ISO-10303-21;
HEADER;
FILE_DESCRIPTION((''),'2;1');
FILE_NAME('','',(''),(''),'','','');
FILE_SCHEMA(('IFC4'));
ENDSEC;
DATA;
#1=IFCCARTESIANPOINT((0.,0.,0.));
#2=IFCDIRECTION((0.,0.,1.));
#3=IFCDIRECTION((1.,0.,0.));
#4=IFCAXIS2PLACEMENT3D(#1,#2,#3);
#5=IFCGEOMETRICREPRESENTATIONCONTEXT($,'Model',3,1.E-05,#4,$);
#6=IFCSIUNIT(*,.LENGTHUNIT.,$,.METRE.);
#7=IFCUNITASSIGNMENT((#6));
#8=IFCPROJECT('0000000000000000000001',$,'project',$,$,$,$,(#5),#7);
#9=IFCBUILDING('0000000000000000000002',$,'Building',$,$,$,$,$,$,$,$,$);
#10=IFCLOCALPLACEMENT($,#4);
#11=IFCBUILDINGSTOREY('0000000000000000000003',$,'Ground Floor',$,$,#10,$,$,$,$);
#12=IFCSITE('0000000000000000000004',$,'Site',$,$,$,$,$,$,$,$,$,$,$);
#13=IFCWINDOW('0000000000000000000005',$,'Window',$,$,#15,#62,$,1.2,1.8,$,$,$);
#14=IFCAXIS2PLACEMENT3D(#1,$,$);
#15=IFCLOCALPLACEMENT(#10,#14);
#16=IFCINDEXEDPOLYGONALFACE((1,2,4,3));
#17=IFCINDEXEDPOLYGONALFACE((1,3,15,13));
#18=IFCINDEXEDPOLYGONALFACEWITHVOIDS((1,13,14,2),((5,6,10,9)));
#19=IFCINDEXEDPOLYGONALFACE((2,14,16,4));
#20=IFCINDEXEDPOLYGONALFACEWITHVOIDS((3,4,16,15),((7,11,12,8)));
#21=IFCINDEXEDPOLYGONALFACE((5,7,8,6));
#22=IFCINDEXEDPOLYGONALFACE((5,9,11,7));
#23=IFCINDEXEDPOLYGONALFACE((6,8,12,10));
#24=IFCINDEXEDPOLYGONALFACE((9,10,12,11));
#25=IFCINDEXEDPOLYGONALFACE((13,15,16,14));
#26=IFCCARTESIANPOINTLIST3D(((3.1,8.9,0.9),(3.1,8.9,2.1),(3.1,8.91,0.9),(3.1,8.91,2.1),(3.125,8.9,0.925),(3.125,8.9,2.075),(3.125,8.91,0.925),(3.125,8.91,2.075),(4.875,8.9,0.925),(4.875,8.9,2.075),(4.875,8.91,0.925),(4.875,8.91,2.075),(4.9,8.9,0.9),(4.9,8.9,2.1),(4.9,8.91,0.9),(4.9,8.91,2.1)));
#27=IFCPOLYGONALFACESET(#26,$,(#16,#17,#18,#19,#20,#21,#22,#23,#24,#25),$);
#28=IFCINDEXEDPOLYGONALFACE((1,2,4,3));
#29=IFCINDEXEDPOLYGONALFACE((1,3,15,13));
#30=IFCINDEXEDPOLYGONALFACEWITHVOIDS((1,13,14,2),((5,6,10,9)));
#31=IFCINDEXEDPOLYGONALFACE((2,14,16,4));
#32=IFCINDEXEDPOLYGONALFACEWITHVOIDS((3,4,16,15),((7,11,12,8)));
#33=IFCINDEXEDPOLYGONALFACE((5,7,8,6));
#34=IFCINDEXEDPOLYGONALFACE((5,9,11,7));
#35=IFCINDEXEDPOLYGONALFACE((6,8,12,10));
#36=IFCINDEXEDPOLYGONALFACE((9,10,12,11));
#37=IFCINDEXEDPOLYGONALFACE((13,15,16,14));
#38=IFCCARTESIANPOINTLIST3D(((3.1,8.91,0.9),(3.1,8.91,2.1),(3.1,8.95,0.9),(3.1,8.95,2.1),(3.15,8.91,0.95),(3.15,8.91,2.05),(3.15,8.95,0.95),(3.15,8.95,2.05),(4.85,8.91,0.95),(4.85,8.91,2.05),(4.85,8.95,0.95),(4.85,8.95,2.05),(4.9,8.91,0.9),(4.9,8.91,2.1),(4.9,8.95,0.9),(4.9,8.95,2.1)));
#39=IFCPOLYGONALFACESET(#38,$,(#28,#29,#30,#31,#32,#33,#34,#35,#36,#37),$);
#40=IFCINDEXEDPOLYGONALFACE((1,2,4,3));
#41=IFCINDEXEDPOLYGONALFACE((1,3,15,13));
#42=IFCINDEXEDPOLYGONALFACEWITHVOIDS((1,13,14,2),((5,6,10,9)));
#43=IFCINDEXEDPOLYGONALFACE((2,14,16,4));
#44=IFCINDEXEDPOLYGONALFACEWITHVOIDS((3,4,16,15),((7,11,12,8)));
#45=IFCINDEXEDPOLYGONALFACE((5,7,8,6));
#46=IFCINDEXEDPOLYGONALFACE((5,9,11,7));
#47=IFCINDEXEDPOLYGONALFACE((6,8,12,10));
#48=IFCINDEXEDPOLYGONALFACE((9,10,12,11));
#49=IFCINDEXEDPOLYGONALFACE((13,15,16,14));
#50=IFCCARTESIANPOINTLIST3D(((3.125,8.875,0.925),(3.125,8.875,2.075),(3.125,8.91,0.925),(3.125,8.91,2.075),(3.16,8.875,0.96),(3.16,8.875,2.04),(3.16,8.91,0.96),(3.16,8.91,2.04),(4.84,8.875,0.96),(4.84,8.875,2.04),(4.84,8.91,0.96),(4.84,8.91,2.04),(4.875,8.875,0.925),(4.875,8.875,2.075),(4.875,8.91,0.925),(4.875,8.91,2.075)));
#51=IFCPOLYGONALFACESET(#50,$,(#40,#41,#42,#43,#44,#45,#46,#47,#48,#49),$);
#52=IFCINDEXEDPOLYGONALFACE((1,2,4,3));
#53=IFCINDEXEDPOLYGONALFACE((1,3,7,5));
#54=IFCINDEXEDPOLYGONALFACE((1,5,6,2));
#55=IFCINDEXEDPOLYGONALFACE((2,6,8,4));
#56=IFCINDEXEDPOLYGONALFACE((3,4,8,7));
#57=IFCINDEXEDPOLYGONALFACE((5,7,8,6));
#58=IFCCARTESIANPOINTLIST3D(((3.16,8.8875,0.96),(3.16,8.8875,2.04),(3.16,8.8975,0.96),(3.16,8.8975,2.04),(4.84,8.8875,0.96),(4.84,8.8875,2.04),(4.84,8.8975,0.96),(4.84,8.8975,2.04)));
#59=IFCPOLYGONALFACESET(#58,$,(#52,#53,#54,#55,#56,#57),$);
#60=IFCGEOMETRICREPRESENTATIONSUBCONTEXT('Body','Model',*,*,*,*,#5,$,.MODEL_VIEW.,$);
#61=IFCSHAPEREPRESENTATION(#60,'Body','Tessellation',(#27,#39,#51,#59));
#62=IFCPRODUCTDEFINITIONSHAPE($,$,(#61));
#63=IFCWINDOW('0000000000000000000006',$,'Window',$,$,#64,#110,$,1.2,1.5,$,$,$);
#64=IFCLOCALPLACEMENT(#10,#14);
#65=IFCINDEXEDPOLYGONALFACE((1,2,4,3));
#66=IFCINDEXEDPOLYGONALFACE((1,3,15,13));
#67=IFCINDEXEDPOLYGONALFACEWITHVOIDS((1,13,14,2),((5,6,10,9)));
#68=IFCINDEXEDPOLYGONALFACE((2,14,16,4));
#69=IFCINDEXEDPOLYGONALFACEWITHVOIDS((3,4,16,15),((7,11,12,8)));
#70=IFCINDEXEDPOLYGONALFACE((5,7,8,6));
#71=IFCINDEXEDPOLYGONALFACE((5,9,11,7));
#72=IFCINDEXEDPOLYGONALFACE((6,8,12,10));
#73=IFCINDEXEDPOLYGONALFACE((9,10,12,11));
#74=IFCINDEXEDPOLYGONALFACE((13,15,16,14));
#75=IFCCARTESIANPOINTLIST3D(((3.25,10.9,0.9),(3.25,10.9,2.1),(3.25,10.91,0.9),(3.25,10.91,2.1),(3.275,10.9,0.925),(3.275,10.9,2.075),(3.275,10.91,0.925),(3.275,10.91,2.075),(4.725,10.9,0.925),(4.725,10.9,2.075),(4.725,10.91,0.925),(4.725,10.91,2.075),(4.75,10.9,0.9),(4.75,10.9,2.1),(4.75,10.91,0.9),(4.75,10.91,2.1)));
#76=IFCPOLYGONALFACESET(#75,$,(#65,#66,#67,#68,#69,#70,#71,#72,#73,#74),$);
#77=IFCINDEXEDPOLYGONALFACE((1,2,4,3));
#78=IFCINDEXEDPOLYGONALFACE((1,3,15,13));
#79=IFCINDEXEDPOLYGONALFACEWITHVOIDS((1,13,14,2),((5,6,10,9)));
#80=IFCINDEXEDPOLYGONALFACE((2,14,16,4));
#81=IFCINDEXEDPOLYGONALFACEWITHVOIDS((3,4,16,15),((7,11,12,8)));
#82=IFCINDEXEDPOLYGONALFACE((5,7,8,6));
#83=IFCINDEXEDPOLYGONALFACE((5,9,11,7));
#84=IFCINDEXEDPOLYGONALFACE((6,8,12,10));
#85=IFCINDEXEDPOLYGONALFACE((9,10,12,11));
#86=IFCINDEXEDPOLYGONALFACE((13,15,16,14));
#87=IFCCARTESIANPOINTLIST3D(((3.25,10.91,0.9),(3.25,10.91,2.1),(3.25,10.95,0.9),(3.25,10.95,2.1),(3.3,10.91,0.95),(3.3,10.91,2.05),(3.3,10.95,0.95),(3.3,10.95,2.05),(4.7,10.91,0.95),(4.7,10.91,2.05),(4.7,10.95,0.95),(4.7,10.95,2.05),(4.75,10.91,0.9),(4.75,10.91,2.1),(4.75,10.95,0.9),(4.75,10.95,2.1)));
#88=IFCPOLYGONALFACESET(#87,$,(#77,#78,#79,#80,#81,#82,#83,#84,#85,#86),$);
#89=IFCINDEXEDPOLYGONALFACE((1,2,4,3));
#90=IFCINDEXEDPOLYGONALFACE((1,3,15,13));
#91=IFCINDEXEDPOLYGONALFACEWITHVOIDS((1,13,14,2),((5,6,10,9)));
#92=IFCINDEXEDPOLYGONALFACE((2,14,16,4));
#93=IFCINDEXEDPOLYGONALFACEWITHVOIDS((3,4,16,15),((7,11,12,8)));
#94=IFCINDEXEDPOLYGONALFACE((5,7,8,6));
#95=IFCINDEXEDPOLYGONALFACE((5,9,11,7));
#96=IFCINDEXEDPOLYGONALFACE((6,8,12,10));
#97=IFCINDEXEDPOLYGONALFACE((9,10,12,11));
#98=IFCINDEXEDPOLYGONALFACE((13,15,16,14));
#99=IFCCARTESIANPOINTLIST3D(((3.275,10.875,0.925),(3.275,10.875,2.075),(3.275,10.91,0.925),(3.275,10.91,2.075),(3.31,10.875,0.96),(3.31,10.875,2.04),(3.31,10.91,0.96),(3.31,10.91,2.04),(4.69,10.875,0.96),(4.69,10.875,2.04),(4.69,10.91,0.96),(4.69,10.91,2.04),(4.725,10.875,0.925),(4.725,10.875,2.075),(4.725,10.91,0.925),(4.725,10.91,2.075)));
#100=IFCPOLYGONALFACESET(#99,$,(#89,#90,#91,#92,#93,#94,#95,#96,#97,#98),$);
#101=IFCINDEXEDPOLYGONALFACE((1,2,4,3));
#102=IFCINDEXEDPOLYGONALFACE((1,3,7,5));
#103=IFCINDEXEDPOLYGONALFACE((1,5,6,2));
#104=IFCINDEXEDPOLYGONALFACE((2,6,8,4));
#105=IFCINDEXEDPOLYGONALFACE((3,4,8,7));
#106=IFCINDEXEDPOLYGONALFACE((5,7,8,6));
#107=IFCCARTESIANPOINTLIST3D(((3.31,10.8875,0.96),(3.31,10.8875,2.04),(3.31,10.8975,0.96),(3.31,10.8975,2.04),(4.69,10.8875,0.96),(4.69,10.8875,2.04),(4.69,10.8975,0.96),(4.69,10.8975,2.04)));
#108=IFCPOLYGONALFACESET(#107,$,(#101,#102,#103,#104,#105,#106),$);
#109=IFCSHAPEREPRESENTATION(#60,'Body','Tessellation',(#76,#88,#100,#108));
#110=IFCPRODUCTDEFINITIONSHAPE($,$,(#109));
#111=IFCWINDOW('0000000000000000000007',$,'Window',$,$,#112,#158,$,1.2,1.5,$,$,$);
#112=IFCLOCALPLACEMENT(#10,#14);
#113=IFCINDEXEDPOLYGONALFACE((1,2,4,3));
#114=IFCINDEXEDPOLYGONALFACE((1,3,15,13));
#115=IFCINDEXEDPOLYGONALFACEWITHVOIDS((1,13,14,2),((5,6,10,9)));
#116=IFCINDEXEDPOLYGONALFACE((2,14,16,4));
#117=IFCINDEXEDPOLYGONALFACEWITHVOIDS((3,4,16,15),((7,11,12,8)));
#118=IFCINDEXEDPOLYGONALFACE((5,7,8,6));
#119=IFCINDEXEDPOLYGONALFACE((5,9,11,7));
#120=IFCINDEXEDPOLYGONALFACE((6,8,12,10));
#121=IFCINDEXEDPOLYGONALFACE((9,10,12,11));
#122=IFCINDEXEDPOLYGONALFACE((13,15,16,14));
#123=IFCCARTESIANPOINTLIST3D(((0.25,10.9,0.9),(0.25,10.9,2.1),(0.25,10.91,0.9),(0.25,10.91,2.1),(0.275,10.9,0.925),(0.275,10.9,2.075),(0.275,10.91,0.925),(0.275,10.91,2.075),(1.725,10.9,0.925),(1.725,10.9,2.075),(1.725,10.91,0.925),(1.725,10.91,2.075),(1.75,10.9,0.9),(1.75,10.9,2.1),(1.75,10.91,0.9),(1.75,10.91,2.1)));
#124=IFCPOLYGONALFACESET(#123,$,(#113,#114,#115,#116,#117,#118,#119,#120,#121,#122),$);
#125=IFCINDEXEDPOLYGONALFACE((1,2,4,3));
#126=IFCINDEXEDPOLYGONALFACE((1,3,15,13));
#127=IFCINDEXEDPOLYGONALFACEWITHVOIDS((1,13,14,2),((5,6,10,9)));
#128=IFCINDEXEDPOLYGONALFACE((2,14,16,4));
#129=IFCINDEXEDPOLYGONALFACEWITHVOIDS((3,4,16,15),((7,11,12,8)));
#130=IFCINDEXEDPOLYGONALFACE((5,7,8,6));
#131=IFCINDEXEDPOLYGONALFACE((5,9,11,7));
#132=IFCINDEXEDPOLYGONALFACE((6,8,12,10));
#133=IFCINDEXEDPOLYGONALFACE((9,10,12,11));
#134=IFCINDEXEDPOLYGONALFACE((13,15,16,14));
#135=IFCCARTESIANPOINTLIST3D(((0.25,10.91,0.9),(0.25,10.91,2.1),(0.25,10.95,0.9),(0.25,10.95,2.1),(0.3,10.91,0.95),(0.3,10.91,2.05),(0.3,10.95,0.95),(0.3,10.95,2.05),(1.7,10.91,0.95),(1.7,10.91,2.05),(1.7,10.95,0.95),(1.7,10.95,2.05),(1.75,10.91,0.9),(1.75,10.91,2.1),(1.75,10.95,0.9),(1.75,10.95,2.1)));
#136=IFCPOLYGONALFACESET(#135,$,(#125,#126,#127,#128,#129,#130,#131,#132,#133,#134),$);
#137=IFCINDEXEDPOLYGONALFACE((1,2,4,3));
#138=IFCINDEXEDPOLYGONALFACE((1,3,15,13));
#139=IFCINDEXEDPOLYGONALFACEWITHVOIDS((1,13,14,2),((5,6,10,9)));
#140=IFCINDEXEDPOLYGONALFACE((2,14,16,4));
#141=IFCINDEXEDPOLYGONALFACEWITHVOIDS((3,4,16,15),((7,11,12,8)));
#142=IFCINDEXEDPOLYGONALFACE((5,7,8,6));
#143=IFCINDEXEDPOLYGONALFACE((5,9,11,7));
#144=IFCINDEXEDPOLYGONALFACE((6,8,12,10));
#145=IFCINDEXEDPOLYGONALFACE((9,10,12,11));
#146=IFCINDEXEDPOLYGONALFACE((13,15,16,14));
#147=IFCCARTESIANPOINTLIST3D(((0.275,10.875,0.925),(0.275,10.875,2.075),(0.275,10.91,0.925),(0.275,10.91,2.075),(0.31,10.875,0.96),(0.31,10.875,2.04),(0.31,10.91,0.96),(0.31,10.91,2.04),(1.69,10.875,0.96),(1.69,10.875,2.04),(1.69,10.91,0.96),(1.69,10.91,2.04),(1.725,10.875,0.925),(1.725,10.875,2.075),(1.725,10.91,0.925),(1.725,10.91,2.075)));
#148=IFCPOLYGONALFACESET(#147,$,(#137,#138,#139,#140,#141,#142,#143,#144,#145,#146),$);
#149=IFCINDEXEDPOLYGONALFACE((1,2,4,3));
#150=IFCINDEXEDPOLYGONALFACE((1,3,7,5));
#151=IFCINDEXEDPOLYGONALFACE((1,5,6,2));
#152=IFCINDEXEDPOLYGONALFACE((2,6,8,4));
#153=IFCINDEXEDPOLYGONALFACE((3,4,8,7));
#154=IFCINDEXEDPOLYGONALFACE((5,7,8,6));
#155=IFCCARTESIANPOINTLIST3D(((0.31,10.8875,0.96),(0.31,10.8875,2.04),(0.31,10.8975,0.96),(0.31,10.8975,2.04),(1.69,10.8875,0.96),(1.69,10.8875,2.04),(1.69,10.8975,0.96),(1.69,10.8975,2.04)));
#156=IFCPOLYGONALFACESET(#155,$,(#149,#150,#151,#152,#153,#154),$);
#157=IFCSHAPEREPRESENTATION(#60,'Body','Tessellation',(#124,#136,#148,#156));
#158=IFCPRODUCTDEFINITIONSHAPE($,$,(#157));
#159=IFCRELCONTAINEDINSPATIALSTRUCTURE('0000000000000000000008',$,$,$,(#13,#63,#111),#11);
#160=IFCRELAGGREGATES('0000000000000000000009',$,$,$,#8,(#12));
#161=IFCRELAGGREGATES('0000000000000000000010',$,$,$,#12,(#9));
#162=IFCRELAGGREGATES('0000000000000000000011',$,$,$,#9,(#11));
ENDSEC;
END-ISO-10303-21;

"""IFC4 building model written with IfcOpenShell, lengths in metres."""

from ifc_helpers import new_model, si_unit, frame, origin_with_axes, place, context, subcontext, project, spatial, line, indexed_curve, outline, extrude, element, save


model = new_model("IFC4")

# Units and contexts
model_context = context("Model", 3, precision=1e-05, world=origin_with_axes())
body_context = subcontext(model_context, "Body", "Model", "MODEL_VIEW")
ifc_project = project(units=[si_unit("LENGTHUNIT", "METRE")], contexts=[model_context])

# Site, building, storey
site = spatial("IfcSite", under=ifc_project, Name="Site")
building = spatial("IfcBuilding", under=site, Name="Building")
storey_placement = place(None, origin_with_axes())
storey = spatial("IfcBuildingStorey", under=building, at=storey_placement, Name="Ground Floor")

# Windows
window_placement = place(storey_placement, frame((4.9, 9.0, 0.9), z_axis=(0.0, 0.0, 1.0), x_axis=(-1.0, 0.0, 0.0)))
element("IfcWindow", 1, at=window_placement, inside=storey, Name="Window", OverallHeight=1.2, OverallWidth=1.8, context=body_context, shape_type="SweptSolid", body=[
    extrude(outline(indexed_curve([(0.0, 0.0), (1.8, 0.0), (1.8, 1.2), (0.0, 1.2)], segments=[line(1, 2, 3, 4, 1)]), holes=[indexed_curve([(0.025, 0.025), (1.775, 0.025), (1.775, 1.175), (0.025, 1.175)], segments=[line(1, 2, 3, 4, 1)])]), frame((0.0, 0.09, 0.0), z_axis=(0.0, -1.0, 0.0), x_axis=(1.0, 0.0, 0.0)), (0.0, 0.0, -1.0), 0.01),
    extrude(outline(indexed_curve([(0.0, 0.0), (1.8, 0.0), (1.8, 1.2), (0.0, 1.2)], segments=[line(1, 2, 3, 4, 1)]), holes=[indexed_curve([(0.05, 0.05), (1.75, 0.05), (1.75, 1.15), (0.05, 1.15)], segments=[line(1, 2, 3, 4, 1)])]), frame((0.0, 0.05, 0.0), z_axis=(0.0, -1.0, 0.0), x_axis=(1.0, 0.0, 0.0)), (0.0, 0.0, -1.0), 0.04),
    extrude(outline(indexed_curve([(0.0, 0.0), (1.75, 0.0), (1.75, 1.15), (0.0, 1.15)], segments=[line(1, 2, 3, 4, 1)]), holes=[indexed_curve([(0.035, 0.035), (1.715, 0.035), (1.715, 1.115), (0.035, 1.115)], segments=[line(1, 2, 3, 4, 1)])]), frame((0.025, 0.09, 0.025), z_axis=(0.0, -1.0, 0.0), x_axis=(1.0, 0.0, 0.0)), (0.0, 0.0, -1.0), 0.035),
    extrude(outline(indexed_curve([(0.035, 0.035), (1.715, 0.035), (1.715, 1.115), (0.035, 1.115)], segments=[line(1, 2, 3, 4, 1)])), frame((0.025, 0.1025, 0.025), z_axis=(0.0, -1.0, 0.0), x_axis=(1.0, 0.0, 0.0)), (0.0, 0.0, -1.0), 0.01),
])
for number, where, z_axis, x_axis, name in (
    (2, (4.75, 11.0, 0.9), (0.0, 0.0, 1.0), (-1.0, 0.0, 0.0), "Window"),
    (3, (1.75, 11.0, 0.9), (0.0, 0.0, 1.0), (-1.0, 0.0, 0.0), "Window"),
):
    element("IfcWindow", number, at=place(storey_placement, frame(where, z_axis=z_axis, x_axis=x_axis)), inside=storey, Name=name, OverallHeight=1.2, OverallWidth=1.5, context=body_context, shape_type="SweptSolid", body=[
        extrude(outline(indexed_curve([(0.0, 0.0), (1.5, 0.0), (1.5, 1.2), (0.0, 1.2)], segments=[line(1, 2, 3, 4, 1)]), holes=[indexed_curve([(0.025, 0.025), (1.475, 0.025), (1.475, 1.175), (0.025, 1.175)], segments=[line(1, 2, 3, 4, 1)])]), frame((0.0, 0.09, 0.0), z_axis=(0.0, -1.0, 0.0), x_axis=(1.0, 0.0, 0.0)), (0.0, 0.0, -1.0), 0.01),
        extrude(outline(indexed_curve([(0.0, 0.0), (1.5, 0.0), (1.5, 1.2), (0.0, 1.2)], segments=[line(1, 2, 3, 4, 1)]), holes=[indexed_curve([(0.05, 0.05), (1.45, 0.05), (1.45, 1.15), (0.05, 1.15)], segments=[line(1, 2, 3, 4, 1)])]), frame((0.0, 0.05, 0.0), z_axis=(0.0, -1.0, 0.0), x_axis=(1.0, 0.0, 0.0)), (0.0, 0.0, -1.0), 0.04),
        extrude(outline(indexed_curve([(0.0, 0.0), (1.45, 0.0), (1.45, 1.15), (0.0, 1.15)], segments=[line(1, 2, 3, 4, 1)]), holes=[indexed_curve([(0.035, 0.035), (1.415, 0.035), (1.415, 1.115), (0.035, 1.115)], segments=[line(1, 2, 3, 4, 1)])]), frame((0.025, 0.09, 0.025), z_axis=(0.0, -1.0, 0.0), x_axis=(1.0, 0.0, 0.0)), (0.0, 0.0, -1.0), 0.035),
        extrude(outline(indexed_curve([(0.035, 0.035), (1.415, 0.035), (1.415, 1.115), (0.035, 1.115)], segments=[line(1, 2, 3, 4, 1)])), frame((0.025, 0.1025, 0.025), z_axis=(0.0, -1.0, 0.0), x_axis=(1.0, 0.0, 0.0)), (0.0, 0.0, -1.0), 0.01),
    ])

save(model, "model.ifc")
